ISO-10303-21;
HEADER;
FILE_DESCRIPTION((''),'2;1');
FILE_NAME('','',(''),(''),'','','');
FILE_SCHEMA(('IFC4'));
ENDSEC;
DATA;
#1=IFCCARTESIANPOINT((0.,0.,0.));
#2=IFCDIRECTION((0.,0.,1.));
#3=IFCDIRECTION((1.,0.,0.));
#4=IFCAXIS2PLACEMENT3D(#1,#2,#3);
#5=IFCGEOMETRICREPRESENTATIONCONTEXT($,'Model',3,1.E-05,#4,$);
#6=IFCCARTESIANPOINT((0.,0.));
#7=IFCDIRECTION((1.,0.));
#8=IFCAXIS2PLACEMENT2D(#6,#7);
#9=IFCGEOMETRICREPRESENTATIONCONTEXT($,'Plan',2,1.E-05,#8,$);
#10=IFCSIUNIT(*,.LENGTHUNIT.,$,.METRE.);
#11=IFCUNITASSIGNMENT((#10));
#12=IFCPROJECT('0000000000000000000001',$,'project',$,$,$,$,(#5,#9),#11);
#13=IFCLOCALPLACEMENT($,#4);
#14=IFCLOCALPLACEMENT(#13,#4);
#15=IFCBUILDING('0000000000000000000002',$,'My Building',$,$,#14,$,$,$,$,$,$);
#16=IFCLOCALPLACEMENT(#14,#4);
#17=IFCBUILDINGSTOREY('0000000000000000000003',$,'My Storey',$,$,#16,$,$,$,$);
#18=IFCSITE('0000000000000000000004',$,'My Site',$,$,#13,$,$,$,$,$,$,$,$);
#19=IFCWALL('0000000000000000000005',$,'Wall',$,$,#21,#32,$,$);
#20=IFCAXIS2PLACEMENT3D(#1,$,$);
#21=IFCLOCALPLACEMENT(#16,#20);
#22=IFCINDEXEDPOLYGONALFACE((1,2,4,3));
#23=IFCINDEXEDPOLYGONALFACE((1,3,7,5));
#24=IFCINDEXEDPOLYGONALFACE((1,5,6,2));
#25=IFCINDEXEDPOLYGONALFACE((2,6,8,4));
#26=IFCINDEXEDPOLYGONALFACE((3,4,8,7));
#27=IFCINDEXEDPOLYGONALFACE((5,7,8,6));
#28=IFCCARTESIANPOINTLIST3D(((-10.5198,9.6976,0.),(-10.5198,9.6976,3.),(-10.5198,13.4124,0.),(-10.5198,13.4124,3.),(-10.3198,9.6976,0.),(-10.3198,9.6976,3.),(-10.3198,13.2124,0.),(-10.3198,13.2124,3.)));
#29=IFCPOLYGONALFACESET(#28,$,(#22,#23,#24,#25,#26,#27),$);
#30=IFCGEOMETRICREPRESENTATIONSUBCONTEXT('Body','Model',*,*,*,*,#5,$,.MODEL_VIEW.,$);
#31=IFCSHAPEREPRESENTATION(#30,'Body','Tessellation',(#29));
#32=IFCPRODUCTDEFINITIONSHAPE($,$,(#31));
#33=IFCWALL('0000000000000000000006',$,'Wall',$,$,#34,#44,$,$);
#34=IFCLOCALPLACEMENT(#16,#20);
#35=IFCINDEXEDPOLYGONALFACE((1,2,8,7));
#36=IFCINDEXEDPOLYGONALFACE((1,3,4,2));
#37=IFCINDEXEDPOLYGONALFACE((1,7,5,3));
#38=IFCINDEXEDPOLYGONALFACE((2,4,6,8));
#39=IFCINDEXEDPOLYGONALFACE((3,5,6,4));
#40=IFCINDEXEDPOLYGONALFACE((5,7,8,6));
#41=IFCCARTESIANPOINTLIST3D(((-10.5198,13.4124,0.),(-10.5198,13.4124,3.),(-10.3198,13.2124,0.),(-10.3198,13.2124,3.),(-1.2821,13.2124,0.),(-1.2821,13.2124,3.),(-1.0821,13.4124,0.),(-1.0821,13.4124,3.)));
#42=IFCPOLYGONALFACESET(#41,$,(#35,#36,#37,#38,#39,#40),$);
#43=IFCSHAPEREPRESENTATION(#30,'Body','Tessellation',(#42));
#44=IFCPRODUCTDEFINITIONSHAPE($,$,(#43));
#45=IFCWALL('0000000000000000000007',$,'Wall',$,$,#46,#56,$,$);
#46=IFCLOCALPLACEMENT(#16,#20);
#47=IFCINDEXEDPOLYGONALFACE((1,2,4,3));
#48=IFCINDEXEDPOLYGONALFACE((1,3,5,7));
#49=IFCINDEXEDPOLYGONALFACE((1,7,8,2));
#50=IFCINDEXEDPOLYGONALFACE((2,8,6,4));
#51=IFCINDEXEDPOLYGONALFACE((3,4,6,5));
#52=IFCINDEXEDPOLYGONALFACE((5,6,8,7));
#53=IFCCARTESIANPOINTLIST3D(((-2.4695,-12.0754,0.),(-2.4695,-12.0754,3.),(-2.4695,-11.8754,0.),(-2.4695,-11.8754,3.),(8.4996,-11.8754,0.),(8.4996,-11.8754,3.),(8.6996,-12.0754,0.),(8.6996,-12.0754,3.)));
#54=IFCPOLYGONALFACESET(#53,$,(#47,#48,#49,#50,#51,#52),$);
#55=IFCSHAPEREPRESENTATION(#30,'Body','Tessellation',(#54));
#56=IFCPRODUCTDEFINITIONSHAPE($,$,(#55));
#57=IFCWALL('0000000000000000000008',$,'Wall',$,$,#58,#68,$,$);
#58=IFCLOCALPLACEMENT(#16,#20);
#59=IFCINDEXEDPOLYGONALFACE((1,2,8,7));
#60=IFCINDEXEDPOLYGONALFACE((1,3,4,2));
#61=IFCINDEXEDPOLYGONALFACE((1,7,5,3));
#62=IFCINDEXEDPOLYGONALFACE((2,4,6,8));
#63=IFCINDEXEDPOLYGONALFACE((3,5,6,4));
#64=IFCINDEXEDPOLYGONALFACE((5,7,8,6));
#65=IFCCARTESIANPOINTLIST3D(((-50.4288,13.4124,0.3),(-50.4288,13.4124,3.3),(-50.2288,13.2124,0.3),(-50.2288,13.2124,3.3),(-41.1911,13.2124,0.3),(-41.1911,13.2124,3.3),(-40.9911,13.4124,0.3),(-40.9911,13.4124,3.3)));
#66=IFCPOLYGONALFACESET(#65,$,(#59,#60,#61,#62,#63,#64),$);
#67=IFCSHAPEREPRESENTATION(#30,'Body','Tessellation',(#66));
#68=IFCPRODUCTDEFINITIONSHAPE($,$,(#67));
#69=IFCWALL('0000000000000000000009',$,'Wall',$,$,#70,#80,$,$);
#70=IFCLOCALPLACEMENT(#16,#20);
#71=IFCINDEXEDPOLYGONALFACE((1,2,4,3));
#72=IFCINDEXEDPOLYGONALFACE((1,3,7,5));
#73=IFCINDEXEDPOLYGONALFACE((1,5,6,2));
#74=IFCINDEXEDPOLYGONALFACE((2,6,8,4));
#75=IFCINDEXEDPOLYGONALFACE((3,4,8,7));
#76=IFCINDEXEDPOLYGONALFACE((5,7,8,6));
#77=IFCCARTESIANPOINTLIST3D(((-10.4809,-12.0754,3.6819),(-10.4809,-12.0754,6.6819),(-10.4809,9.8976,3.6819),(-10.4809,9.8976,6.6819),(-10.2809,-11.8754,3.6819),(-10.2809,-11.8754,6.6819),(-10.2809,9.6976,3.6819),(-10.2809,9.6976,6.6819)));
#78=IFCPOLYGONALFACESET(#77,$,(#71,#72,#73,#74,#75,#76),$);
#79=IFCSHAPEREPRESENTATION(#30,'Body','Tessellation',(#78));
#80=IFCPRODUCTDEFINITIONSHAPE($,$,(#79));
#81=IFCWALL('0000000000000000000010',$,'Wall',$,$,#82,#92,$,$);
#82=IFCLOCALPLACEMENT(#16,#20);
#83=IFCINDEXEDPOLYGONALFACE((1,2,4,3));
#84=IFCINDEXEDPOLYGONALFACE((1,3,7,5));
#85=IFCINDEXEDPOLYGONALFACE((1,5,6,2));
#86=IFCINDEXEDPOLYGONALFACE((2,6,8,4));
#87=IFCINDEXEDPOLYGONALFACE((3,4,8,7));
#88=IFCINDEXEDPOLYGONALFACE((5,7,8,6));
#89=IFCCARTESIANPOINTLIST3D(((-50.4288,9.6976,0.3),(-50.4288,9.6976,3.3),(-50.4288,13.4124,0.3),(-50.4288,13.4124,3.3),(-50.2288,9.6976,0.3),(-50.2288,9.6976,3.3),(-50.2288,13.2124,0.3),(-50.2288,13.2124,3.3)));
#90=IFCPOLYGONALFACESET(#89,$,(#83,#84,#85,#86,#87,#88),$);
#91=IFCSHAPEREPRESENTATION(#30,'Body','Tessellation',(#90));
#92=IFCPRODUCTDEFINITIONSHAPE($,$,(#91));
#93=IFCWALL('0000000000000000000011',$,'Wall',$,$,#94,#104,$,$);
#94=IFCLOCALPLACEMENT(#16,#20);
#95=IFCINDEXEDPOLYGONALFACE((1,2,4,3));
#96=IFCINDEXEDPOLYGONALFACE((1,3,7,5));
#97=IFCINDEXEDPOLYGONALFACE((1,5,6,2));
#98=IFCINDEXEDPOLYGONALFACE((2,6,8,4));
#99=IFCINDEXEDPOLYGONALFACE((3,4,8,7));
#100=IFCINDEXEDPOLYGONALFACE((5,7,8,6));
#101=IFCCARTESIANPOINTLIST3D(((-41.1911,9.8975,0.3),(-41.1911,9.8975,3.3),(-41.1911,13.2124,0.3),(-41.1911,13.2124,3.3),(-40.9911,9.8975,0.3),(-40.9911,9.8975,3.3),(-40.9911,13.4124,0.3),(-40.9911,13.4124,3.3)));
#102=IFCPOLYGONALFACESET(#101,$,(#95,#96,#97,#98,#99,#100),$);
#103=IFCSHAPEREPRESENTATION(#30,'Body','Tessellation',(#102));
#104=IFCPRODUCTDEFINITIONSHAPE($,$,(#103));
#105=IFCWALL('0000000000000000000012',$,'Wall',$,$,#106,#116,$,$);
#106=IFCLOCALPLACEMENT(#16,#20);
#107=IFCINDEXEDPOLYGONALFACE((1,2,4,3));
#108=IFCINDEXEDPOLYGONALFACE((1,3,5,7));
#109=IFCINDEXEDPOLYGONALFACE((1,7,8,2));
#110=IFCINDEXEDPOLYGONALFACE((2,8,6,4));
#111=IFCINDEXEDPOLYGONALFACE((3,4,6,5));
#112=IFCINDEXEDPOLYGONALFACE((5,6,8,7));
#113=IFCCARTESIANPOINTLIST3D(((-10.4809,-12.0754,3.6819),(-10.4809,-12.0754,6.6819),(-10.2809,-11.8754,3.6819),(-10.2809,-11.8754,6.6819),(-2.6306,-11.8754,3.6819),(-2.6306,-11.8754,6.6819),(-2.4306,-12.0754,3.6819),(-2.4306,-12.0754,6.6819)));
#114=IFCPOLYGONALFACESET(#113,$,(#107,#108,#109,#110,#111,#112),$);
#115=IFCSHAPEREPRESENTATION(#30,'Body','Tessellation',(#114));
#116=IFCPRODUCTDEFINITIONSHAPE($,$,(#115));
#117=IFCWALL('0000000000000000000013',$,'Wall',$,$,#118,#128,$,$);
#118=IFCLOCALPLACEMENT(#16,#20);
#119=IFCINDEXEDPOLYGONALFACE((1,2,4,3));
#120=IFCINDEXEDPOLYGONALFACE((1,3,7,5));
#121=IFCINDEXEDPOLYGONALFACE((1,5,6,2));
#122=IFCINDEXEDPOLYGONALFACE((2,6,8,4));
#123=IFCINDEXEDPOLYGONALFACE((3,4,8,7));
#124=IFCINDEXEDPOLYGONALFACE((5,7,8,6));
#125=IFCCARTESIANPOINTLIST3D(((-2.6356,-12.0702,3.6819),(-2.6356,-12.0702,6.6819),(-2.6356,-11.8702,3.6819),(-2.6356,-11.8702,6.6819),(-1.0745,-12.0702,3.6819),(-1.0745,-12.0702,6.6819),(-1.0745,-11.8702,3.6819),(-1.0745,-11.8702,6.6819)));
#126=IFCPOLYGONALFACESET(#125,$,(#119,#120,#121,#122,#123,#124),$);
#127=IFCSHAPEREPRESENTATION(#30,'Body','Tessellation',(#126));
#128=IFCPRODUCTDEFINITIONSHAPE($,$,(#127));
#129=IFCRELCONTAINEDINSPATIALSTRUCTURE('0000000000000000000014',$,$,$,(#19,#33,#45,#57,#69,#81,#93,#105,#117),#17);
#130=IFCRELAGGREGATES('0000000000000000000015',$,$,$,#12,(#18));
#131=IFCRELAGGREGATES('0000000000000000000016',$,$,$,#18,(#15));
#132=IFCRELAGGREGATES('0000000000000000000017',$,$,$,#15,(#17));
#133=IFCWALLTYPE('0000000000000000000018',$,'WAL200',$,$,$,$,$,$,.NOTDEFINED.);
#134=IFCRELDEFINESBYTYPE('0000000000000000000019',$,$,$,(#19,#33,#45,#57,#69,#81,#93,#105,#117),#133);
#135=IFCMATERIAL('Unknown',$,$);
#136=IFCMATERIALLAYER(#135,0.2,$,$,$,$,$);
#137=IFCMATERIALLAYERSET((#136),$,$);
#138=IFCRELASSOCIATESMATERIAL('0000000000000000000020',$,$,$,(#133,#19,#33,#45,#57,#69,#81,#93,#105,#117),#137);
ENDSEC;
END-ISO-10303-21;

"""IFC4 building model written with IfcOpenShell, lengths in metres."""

from ifc_helpers import new_model, si_unit, frame, origin_with_axes, origin_2d_with_axis, place, context, subcontext, project, spatial, line, indexed_curve, outline, extrude, material, layer, layer_set, layer_usage, type_object, element, save


model = new_model("IFC4")

# Units and contexts
model_context = context("Model", 3, precision=1e-05, world=origin_with_axes())
plan_context = context("Plan", 2, precision=1e-05, world=origin_2d_with_axis())
body_context_1 = subcontext(model_context, "Body", "Model", "MODEL_VIEW")
ifc_project = project(units=[si_unit("LENGTHUNIT", "METRE")], contexts=[model_context, plan_context])

# Site, building, storey
site_placement = place(None, origin_with_axes())
site = spatial("IfcSite", under=ifc_project, at=site_placement, Name="My Site")
building_placement = place(site_placement, origin_with_axes())
building = spatial("IfcBuilding", under=site, at=building_placement, Name="My Building")
storey_placement = place(building_placement, origin_with_axes())
storey = spatial("IfcBuildingStorey", under=building, at=storey_placement, Name="My Storey")

# Shared definitions
ifc_material = material(Name="Unknown")

# Shared definitions
ifc_layer_1 = layer(ifc_material, 0.2)
ifc_layer_set_1 = layer_set([ifc_layer_1])
wall_type_1 = type_object("IfcWallType", Name="WAL200", PredefinedType="NOTDEFINED", material=ifc_layer_set_1)

# Walls
ifc_layer_usage_1 = layer_usage(ifc_layer_set_1, "AXIS2", "POSITIVE", 0.0)
wall_1_placement = place(storey_placement, frame((-10.3198, 9.6976, 0.0), z_axis=(0.0, 0.0, 1.0), x_axis=(0.0, 1.0, 0.0)))
element("IfcWall", 1, at=wall_1_placement, inside=storey, type_object=wall_type_1, material=ifc_layer_usage_1, Name="Wall", context=body_context_1, shape_type="SweptSolid", body=[
    extrude(outline(indexed_curve([(0.0, 0.0), (0.0, 0.2), (3.7148, 0.2), (3.5148, 0.0)], segments=[line(1, 2, 3, 4, 1)])), origin_with_axes(), (0.0, 0.0, 1.0), 3.0),
])
ifc_layer_usage_2 = layer_usage(ifc_layer_set_1, "AXIS2", "POSITIVE", 0.0)
wall_2_placement = place(storey_placement, frame((-10.3198, 13.2124, 0.0), z_axis=(0.0, 0.0, 1.0), x_axis=(1.0, 0.0, 0.0)))
element("IfcWall", 2, at=wall_2_placement, inside=storey, type_object=wall_type_1, material=ifc_layer_usage_2, Name="Wall", context=body_context_1, shape_type="SweptSolid", body=[
    extrude(outline(indexed_curve([(0.0, 0.0), (-0.2, 0.2), (9.2377, 0.2), (9.0377, 0.0)], segments=[line(1, 2, 3, 4, 1)])), origin_with_axes(), (0.0, 0.0, 1.0), 3.0),
])
ifc_layer_usage_3 = layer_usage(ifc_layer_set_1, "AXIS2", "POSITIVE", 0.0)
wall_3_placement = place(storey_placement, frame((-2.4695, -12.0754, 0.0), z_axis=(0.0, 0.0, 1.0), x_axis=(1.0, 0.0, 0.0)))
element("IfcWall", 3, at=wall_3_placement, inside=storey, type_object=wall_type_1, material=ifc_layer_usage_3, Name="Wall", context=body_context_1, shape_type="SweptSolid", body=[
    extrude(outline(indexed_curve([(0.0, 0.0), (0.0, 0.2), (10.9692, 0.2), (11.1692, 0.0)], segments=[line(1, 2, 3, 4, 1)])), origin_with_axes(), (0.0, 0.0, 1.0), 3.0),
])
ifc_layer_usage_4 = layer_usage(ifc_layer_set_1, "AXIS2", "POSITIVE", 0.0)
wall_4_placement = place(storey_placement, frame((-50.2288, 13.2124, 0.3), z_axis=(0.0, 0.0, 1.0), x_axis=(1.0, 0.0, 0.0)))
element("IfcWall", 4, at=wall_4_placement, inside=storey, type_object=wall_type_1, material=ifc_layer_usage_4, Name="Wall", context=body_context_1, shape_type="SweptSolid", body=[
    extrude(outline(indexed_curve([(0.0, 0.0), (-0.2, 0.2), (9.2377, 0.2), (9.0377, 0.0)], segments=[line(1, 2, 3, 4, 1)])), origin_with_axes(), (0.0, 0.0, 1.0), 3.0),
])
ifc_layer_usage_5 = layer_usage(ifc_layer_set_1, "AXIS2", "POSITIVE", 0.0)
wall_5_placement = place(storey_placement, frame((-10.4809, 9.8976, 3.6819), z_axis=(0.0, 0.0, 1.0), x_axis=(0.0, -1.0, 0.0)))
element("IfcWall", 5, at=wall_5_placement, inside=storey, type_object=wall_type_1, material=ifc_layer_usage_5, Name="Wall", context=body_context_1, shape_type="SweptSolid", body=[
    extrude(outline(indexed_curve([(0.0, 0.0), (0.2, 0.2), (21.773, 0.2), (21.973, 0.0)], segments=[line(1, 2, 3, 4, 1)])), origin_with_axes(), (0.0, 0.0, 1.0), 3.0),
])
ifc_layer_usage_6 = layer_usage(ifc_layer_set_1, "AXIS2", "POSITIVE", 0.0)
wall_6_placement = place(storey_placement, frame((-50.2288, 9.6976, 0.3), z_axis=(0.0, 0.0, 1.0), x_axis=(0.0, 1.0, 0.0)))
element("IfcWall", 6, at=wall_6_placement, inside=storey, type_object=wall_type_1, material=ifc_layer_usage_6, Name="Wall", context=body_context_1, shape_type="SweptSolid", body=[
    extrude(outline(indexed_curve([(0.0, 0.0), (0.0, 0.2), (3.7148, 0.2), (3.5148, 0.0)], segments=[line(1, 2, 3, 4, 1)])), origin_with_axes(), (0.0, 0.0, 1.0), 3.0),
])
ifc_layer_usage_7 = layer_usage(ifc_layer_set_1, "AXIS2", "POSITIVE", 0.0)
wall_7_placement = place(storey_placement, frame((-41.1911, 13.2124, 0.3), z_axis=(0.0, 0.0, 1.0), x_axis=(0.0, -1.0, 0.0)))
element("IfcWall", 7, at=wall_7_placement, inside=storey, type_object=wall_type_1, material=ifc_layer_usage_7, Name="Wall", context=body_context_1, shape_type="SweptSolid", body=[
    extrude(outline(indexed_curve([(0.0, 0.0), (-0.2, 0.2), (3.3149, 0.2), (3.3149, 0.0)], segments=[line(1, 2, 3, 4, 1)])), origin_with_axes(), (0.0, 0.0, 1.0), 3.0),
])
ifc_layer_usage_8 = layer_usage(ifc_layer_set_1, "AXIS2", "POSITIVE", 0.0)
wall_8_placement = place(storey_placement, frame((-10.4809, -12.0754, 3.6819), z_axis=(0.0, 0.0, 1.0), x_axis=(1.0, 0.0, 0.0)))
element("IfcWall", 8, at=wall_8_placement, inside=storey, type_object=wall_type_1, material=ifc_layer_usage_8, Name="Wall", context=body_context_1, shape_type="SweptSolid", body=[
    extrude(outline(indexed_curve([(0.0, 0.0), (0.2, 0.2), (7.8503, 0.2), (8.0503, 0.0)], segments=[line(1, 2, 3, 4, 1)])), origin_with_axes(), (0.0, 0.0, 1.0), 3.0),
])
ifc_layer_usage_9 = layer_usage(ifc_layer_set_1, "AXIS2", "POSITIVE", 0.0)
wall_9_placement = place(storey_placement, frame((-2.6356, -12.0702, 3.6819), z_axis=(0.0, 0.0, 1.0), x_axis=(1.0, 0.0, 0.0)))
element("IfcWall", 9, at=wall_9_placement, inside=storey, type_object=wall_type_1, material=ifc_layer_usage_9, Name="Wall", context=body_context_1, shape_type="SweptSolid", body=[
    extrude(outline(indexed_curve([(0.0, 0.0), (0.0, 0.2), (1.5611, 0.2), (1.5611, 0.0)], segments=[line(1, 2, 3, 4, 1)])), origin_with_axes(), (0.0, 0.0, 1.0), 3.0),
])

save(model, "model.ifc")
